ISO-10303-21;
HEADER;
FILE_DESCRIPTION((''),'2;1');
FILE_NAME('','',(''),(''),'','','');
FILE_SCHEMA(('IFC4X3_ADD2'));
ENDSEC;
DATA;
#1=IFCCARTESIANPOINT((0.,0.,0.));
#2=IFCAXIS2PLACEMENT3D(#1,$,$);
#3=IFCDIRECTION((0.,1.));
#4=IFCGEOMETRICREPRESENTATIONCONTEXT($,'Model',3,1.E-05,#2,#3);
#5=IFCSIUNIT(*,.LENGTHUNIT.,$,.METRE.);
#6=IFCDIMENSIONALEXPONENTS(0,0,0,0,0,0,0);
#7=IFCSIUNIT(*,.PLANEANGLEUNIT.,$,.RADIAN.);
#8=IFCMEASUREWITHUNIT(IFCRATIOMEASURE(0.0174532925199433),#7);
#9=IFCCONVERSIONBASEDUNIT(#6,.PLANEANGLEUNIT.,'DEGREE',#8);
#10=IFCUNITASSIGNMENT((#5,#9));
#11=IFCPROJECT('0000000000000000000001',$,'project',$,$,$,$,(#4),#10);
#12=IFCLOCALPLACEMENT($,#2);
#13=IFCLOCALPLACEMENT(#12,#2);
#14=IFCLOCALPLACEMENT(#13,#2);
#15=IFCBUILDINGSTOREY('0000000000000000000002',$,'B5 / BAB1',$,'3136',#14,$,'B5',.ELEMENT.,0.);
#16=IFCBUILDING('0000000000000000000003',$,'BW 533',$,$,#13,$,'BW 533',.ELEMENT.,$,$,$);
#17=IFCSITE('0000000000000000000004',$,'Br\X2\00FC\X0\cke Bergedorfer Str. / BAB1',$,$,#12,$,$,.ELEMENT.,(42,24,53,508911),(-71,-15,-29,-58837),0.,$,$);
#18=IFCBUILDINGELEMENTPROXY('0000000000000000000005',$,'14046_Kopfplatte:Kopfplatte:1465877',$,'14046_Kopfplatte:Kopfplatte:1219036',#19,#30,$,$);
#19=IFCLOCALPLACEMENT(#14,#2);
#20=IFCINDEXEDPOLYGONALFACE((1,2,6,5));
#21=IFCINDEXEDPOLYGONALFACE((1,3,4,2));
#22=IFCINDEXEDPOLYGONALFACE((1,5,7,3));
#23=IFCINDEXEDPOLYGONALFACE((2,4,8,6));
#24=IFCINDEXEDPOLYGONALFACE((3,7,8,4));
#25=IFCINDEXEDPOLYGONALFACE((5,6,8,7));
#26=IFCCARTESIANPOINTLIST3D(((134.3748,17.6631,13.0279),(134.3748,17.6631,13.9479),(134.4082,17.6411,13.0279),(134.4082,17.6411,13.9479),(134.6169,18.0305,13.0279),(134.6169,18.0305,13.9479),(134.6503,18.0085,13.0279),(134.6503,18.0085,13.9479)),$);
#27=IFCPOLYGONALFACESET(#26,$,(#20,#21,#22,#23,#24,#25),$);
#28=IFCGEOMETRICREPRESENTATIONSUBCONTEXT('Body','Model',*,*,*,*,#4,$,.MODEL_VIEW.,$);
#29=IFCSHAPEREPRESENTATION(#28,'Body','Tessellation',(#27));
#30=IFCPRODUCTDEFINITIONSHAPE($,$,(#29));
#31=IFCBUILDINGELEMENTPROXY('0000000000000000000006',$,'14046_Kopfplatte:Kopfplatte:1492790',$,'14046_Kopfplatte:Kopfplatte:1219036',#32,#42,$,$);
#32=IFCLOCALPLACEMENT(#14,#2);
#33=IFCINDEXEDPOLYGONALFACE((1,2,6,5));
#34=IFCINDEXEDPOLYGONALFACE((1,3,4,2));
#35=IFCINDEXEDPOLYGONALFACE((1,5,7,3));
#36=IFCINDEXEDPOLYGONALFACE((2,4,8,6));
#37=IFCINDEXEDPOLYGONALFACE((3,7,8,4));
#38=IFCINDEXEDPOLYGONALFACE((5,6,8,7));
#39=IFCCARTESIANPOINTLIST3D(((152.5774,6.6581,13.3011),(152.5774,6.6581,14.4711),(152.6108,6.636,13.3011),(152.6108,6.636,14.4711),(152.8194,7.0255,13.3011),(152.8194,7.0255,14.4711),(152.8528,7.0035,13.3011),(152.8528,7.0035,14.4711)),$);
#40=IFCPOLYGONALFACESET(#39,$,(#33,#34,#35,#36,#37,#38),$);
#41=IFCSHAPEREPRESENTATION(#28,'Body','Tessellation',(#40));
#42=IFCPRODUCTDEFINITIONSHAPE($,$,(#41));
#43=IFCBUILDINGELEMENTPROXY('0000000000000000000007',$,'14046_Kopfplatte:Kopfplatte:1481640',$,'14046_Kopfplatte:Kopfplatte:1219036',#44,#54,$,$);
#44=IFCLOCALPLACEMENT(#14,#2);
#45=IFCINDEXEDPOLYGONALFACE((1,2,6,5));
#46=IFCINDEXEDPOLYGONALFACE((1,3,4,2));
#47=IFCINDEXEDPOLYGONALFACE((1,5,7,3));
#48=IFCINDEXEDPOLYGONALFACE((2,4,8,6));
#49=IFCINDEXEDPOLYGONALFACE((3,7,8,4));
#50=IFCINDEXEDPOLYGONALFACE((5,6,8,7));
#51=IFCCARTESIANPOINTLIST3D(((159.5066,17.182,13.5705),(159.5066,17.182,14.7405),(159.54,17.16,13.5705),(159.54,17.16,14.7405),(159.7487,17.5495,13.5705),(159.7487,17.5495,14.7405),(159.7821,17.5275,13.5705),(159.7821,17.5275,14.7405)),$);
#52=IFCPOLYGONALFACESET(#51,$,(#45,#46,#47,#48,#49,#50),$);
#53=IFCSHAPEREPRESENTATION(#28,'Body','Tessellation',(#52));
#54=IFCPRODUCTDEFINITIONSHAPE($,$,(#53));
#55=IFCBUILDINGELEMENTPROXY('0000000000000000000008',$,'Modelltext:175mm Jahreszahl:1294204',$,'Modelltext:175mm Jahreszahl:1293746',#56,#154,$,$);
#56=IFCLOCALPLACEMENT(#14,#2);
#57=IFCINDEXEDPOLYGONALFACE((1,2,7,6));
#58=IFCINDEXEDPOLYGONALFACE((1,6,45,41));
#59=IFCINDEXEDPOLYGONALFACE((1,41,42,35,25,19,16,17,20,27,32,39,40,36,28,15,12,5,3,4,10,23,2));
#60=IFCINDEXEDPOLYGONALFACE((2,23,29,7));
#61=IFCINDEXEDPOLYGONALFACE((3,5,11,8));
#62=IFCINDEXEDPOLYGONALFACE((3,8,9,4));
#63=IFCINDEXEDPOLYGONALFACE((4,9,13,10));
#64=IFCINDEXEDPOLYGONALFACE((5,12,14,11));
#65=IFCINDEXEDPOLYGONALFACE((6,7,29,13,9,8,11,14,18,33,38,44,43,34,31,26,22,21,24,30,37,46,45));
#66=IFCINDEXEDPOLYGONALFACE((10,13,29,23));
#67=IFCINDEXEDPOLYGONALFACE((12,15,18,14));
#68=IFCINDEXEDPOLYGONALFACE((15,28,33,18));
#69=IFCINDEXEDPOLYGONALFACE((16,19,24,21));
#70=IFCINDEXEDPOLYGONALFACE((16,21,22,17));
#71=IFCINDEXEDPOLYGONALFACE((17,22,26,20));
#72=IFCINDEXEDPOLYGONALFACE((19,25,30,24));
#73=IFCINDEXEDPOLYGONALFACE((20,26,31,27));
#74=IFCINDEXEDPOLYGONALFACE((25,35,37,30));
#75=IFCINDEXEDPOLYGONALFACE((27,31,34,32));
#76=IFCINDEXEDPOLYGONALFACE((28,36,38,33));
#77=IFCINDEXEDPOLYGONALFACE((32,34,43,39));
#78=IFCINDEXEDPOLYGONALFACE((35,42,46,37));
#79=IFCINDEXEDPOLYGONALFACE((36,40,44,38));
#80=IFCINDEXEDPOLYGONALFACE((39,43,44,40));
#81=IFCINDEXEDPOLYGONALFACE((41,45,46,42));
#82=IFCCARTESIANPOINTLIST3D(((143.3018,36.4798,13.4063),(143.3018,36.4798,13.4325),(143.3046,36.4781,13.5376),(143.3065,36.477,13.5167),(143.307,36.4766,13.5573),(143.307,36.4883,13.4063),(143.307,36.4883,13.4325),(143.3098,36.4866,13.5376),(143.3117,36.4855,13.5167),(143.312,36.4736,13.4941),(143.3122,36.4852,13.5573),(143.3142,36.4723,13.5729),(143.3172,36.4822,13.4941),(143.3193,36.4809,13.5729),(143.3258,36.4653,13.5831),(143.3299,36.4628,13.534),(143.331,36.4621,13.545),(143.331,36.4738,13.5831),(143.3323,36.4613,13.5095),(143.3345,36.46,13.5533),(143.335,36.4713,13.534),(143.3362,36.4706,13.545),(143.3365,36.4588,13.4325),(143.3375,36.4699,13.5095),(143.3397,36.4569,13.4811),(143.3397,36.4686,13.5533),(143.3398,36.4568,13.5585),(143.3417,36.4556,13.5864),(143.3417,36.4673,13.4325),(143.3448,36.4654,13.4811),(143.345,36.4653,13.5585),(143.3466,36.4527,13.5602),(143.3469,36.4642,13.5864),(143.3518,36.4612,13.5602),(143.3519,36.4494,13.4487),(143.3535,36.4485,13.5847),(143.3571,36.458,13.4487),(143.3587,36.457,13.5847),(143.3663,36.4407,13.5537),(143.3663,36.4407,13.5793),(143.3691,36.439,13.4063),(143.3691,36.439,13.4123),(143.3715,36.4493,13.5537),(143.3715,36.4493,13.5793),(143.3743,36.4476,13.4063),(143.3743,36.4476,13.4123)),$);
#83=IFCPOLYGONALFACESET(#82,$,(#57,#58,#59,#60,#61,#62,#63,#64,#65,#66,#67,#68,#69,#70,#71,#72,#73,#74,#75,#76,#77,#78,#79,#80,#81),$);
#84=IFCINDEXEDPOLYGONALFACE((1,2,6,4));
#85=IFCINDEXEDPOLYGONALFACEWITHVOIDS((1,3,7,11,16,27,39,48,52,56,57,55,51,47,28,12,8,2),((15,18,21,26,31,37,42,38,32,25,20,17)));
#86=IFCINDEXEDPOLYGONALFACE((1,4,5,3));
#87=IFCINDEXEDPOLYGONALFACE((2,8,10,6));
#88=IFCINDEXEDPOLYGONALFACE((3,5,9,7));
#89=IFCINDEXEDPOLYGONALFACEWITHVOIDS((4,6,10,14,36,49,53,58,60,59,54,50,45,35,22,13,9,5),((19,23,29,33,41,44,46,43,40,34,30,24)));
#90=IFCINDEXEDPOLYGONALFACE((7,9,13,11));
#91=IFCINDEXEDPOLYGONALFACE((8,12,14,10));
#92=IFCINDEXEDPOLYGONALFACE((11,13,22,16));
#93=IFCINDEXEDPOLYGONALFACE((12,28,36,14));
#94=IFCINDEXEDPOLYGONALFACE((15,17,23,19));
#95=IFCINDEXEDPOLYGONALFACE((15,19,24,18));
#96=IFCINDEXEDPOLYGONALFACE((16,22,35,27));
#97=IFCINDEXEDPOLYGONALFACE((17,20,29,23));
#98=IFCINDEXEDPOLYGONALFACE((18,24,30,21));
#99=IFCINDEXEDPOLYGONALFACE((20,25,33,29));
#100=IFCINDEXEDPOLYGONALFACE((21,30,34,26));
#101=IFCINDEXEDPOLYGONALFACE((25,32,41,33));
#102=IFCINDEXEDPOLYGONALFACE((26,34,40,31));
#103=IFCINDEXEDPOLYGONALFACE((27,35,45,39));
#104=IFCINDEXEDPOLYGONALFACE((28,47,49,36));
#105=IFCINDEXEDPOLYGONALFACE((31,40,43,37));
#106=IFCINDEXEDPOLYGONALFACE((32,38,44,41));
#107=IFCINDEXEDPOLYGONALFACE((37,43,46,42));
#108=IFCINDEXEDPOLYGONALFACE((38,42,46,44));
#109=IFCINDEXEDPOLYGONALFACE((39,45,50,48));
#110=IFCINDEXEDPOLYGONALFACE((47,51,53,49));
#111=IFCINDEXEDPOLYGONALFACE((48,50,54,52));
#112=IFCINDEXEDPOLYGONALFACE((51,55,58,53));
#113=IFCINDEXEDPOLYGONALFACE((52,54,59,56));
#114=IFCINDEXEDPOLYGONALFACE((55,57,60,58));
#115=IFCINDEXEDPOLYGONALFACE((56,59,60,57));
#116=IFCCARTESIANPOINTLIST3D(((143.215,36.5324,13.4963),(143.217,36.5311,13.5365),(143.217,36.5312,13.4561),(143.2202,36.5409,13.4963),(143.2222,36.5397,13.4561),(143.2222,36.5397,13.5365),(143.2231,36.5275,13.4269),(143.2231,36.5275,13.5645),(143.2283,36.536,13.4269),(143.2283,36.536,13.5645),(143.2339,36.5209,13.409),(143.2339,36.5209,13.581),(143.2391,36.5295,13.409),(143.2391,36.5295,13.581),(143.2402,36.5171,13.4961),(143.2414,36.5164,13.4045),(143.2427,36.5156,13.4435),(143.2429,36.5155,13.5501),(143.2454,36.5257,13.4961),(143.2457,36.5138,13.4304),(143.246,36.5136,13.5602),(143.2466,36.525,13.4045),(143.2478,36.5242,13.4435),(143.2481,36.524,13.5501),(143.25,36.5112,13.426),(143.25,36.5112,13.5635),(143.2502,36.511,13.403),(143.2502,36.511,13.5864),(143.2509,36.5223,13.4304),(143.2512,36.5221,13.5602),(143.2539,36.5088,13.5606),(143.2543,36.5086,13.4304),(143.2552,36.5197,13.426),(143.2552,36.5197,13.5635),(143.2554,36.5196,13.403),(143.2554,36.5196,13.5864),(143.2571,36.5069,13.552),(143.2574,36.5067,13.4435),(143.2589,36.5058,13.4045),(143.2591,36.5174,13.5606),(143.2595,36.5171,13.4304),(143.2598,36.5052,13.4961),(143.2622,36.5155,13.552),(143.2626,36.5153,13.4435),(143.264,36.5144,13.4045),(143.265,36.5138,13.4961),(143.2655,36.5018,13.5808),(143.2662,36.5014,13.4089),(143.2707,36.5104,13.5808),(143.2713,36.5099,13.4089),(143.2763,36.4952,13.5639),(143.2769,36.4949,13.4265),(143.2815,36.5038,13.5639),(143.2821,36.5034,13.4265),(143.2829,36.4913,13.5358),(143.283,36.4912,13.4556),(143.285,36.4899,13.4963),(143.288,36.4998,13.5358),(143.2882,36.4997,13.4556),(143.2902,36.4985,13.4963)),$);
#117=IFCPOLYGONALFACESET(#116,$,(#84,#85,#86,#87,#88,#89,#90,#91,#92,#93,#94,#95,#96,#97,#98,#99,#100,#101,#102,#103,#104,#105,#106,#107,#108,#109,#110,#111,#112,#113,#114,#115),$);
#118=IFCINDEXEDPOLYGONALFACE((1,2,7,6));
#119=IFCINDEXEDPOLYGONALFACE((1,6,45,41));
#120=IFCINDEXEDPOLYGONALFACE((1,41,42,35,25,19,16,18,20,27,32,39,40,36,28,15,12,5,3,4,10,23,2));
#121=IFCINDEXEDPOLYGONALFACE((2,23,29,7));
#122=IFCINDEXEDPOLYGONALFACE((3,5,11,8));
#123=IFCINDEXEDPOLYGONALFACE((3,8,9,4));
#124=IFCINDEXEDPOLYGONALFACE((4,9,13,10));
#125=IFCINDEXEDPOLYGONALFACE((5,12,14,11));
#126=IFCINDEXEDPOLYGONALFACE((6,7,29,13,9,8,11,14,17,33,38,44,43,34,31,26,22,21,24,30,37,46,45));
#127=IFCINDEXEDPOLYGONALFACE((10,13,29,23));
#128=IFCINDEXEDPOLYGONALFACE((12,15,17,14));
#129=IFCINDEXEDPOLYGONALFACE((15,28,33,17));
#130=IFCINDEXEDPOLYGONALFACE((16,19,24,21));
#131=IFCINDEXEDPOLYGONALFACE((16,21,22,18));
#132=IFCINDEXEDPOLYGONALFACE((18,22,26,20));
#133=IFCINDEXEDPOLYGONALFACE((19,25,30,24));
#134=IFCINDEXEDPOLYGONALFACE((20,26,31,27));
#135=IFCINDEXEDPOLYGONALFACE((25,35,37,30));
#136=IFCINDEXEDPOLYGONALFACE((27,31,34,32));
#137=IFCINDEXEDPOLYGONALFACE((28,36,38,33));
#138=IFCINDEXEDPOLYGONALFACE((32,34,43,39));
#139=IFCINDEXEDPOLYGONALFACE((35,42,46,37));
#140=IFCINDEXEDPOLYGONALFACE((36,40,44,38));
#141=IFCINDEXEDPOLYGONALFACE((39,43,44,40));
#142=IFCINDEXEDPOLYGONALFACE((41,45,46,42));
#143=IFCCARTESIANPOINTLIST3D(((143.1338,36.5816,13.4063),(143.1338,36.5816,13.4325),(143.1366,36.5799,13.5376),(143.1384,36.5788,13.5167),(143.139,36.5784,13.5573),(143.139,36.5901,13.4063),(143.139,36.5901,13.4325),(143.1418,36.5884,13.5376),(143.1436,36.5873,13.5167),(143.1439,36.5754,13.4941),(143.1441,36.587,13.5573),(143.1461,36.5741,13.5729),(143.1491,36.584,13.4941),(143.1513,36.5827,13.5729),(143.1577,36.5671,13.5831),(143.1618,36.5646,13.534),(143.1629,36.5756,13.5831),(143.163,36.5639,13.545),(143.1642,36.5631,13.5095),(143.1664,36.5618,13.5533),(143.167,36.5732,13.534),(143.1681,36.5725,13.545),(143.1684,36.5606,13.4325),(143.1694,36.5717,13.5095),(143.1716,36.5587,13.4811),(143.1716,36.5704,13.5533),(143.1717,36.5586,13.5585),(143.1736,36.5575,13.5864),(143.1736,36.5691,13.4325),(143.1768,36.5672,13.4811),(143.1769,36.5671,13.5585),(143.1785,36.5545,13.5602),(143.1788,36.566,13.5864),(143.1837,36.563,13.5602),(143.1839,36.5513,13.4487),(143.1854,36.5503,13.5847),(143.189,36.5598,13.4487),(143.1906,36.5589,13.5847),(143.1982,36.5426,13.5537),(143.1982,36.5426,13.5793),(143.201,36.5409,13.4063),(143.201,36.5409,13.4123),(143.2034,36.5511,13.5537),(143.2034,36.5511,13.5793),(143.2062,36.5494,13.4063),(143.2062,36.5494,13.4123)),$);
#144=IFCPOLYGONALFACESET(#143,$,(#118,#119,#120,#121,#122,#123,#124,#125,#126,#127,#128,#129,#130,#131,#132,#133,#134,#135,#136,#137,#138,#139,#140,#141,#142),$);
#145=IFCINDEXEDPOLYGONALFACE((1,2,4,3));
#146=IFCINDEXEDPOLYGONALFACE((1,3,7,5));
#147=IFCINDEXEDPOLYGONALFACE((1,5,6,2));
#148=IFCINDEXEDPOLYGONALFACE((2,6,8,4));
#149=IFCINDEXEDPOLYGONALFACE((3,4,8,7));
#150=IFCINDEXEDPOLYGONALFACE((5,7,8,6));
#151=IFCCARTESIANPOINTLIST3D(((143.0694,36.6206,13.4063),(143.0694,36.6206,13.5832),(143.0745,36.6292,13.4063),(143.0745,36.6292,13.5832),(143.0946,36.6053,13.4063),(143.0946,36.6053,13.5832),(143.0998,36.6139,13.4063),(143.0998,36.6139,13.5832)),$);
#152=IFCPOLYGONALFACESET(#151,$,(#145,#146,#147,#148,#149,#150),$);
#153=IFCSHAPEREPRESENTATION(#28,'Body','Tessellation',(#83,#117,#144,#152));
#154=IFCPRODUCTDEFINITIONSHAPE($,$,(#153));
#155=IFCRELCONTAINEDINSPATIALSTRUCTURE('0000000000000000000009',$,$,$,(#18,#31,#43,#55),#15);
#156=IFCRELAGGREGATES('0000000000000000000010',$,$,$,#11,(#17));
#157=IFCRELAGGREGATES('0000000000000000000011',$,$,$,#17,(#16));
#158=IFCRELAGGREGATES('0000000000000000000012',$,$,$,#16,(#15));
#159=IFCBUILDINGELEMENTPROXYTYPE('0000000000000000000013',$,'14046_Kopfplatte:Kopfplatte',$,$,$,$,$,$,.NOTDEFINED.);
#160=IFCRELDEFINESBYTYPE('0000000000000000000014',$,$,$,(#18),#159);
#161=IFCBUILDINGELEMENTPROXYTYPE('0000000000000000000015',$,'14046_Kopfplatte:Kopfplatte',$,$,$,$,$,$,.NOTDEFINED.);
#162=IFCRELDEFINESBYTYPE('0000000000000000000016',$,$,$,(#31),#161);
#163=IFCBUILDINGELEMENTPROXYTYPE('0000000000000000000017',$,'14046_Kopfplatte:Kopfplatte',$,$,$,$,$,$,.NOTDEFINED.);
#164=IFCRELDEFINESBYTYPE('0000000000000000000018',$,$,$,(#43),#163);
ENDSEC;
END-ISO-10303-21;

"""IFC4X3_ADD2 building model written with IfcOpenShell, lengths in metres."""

from ifc_helpers import new_model, entity, si_unit, converted_unit, direction, frame, frame_2d, origin, origin_2d_with_axis, place, context, subcontext, project, spatial, polyline, rectangle, outline, extrude, source, transform, mapped, type_object, type_shapes, element, save


model = new_model("IFC4X3_ADD2")

# Units and contexts
model_context = context("Model", 3, precision=1e-05, world=origin(), true_north=direction((0.0, 1.0)))
body_context = subcontext(model_context, "Body", "Model", "MODEL_VIEW")
ifc_project = project(units=[si_unit("LENGTHUNIT", "METRE"), converted_unit("PLANEANGLEUNIT", "DEGREE", entity("IfcRatioMeasure", 0.0174532925199433), si_unit("PLANEANGLEUNIT", "RADIAN"), dimensions=[0, 0, 0, 0, 0, 0, 0])], contexts=[model_context])

# Site, building, storey
site_placement = place(None, origin())
site = spatial("IfcSite", under=ifc_project, at=site_placement, Name="Brücke Bergedorfer Str. / BAB1", CompositionType="ELEMENT", RefLatitude=(42, 24, 53, 508911), RefLongitude=(-71, -15, -29, -58837), RefElevation=0.0)
building_placement = place(site_placement, origin())
building = spatial("IfcBuilding", under=site, at=building_placement, Name="BW 533", LongName="BW 533", CompositionType="ELEMENT")
storey_placement = place(building_placement, origin())
storey = spatial("IfcBuildingStorey", under=building, at=storey_placement, Name="B5 / BAB1", ObjectType="3136", LongName="B5", CompositionType="ELEMENT", Elevation=0.0)

# Building element proxies
building_element_proxy_type_1 = type_object("IfcBuildingElementProxyType", Name="14046_Kopfplatte:Kopfplatte", PredefinedType="NOTDEFINED")
shared_shape_1 = source(origin(), body_context, "Body", "SweptSolid", [
    extrude(rectangle(XDim=0.04, YDim=0.44, at=frame_2d((0.0, 0.0), x_axis=(1.0, 0.0))), frame((134.5126, 17.8358, 13.0279), z_axis=(0.0, 0.0, 1.0), x_axis=(-0.835088, 0.550116, 0.0)), (0.0, 0.0, 1.0), 0.92),
])
type_shapes(building_element_proxy_type_1, [shared_shape_1])
proxy_1_placement = place(storey_placement, origin())
element("IfcBuildingElementProxy", 1, at=proxy_1_placement, inside=storey, type_object=building_element_proxy_type_1, Name="14046_Kopfplatte:Kopfplatte:1465877", ObjectType="14046_Kopfplatte:Kopfplatte:1219036", context=body_context, shape_type="MappedRepresentation", body=[
    mapped(shared_shape_1, transform((0.0, 0.0, 0.0), scale=1.0)),
])
building_element_proxy_type_2 = type_object("IfcBuildingElementProxyType", Name="14046_Kopfplatte:Kopfplatte", PredefinedType="NOTDEFINED")
shared_shape_2 = source(origin(), body_context, "Body", "SweptSolid", [
    extrude(rectangle(XDim=0.04, YDim=0.44, at=origin_2d_with_axis()), frame((152.7151, 6.8308, 13.3011), z_axis=(0.0, 0.0, 1.0), x_axis=(0.835088, -0.550116, 0.0)), (0.0, 0.0, 1.0), 1.17),
])
type_shapes(building_element_proxy_type_2, [shared_shape_2])
proxy_2_placement = place(storey_placement, origin())
element("IfcBuildingElementProxy", 2, at=proxy_2_placement, inside=storey, type_object=building_element_proxy_type_2, Name="14046_Kopfplatte:Kopfplatte:1492790", ObjectType="14046_Kopfplatte:Kopfplatte:1219036", context=body_context, shape_type="MappedRepresentation", body=[
    mapped(shared_shape_2, transform((0.0, 0.0, 0.0), scale=1.0)),
])
building_element_proxy_type_3 = type_object("IfcBuildingElementProxyType", Name="14046_Kopfplatte:Kopfplatte", PredefinedType="NOTDEFINED")
shared_shape_3 = source(origin(), body_context, "Body", "SweptSolid", [
    extrude(rectangle(XDim=0.04, YDim=0.44, at=frame_2d((0.0, 0.0), x_axis=(1.0, 0.0))), frame((159.6443, 17.3547, 13.5705), z_axis=(0.0, 0.0, 1.0), x_axis=(0.835088, -0.550116, 0.0)), (0.0, 0.0, 1.0), 1.17),
])
type_shapes(building_element_proxy_type_3, [shared_shape_3])
proxy_3_placement = place(storey_placement, origin())
element("IfcBuildingElementProxy", 3, at=proxy_3_placement, inside=storey, type_object=building_element_proxy_type_3, Name="14046_Kopfplatte:Kopfplatte:1481640", ObjectType="14046_Kopfplatte:Kopfplatte:1219036", context=body_context, shape_type="MappedRepresentation", body=[
    mapped(shared_shape_3, transform((0.0, 0.0, 0.0), scale=1.0)),
])
proxy_4_placement = place(storey_placement, origin())
element("IfcBuildingElementProxy", 4, at=proxy_4_placement, inside=storey, Name="Modelltext:175mm Jahreszahl:1294204", ObjectType="Modelltext:175mm Jahreszahl:1293746", context=body_context, shape_type="SweptSolid", body=[
    extrude(outline(polyline([(-0.041, -0.1087), (0.0376, -0.1087), (0.0376, -0.0825), (-0.0029, -0.0825), (0.0257, -0.021), (0.0322, 0.0016), (0.0343, 0.0226), (0.0315, 0.0423), (0.0232, 0.0579), (0.0096, 0.068), (-0.009, 0.0714), (-0.0228, 0.0696), (-0.0377, 0.0643), (-0.0377, 0.0386), (-0.0147, 0.0452), (-0.0068, 0.0434), (-0.0006, 0.0382), (0.0035, 0.0299), (0.0048, 0.019), (0.002, -0.0055), (-0.0066, -0.034), (-0.021, -0.0664), (-0.041, -0.1027), (-0.041, -0.1087)])), frame((143.334, 36.4603, 13.515), z_axis=(0.518179, 0.855272, 0.0), x_axis=(-0.855272, 0.518179, 0.0)), (0.0, 0.0, 1.0), 0.01),
    extrude(outline(polyline([(-0.012, -0.0814), (-0.0015, -0.0814), (0.0078, -0.0783), (0.0228, -0.0624), (0.034, -0.0344), (0.042, 0.005), (0.0454, 0.0451), (0.0423, 0.0739), (0.0321, 0.092), (0.0141, 0.1001), (-0.0044, 0.097), (-0.0194, 0.0821), (-0.0309, 0.0553), (-0.039, 0.0167), (-0.0424, -0.024), (-0.0395, -0.0538), (-0.0296, -0.073), (-0.0218, -0.0786), (-0.012, -0.0814)]), holes=[polyline([(0.0128, 0.009), (0.0025, -0.0427), (-0.0029, -0.0552), (-0.0084, -0.0588), (-0.0128, -0.0537), (-0.0145, -0.0402), (-0.0099, 0.0123), (0.0013, 0.0671), (0.0062, 0.0752), (0.0111, 0.0774), (0.0152, 0.0734), (0.0174, 0.0629), (0.0128, 0.009)])]), frame((143.25, 36.5112, 13.4854), z_axis=(0.518179, 0.855272, 0.0), x_axis=(-0.846595, 0.512922, 0.142084)), (0.0, 0.0, 1.0), 0.01),
    extrude(outline(polyline([(-0.041, -0.1087), (0.0376, -0.1087), (0.0376, -0.0825), (-0.0029, -0.0825), (0.0257, -0.021), (0.0322, 0.0016), (0.0343, 0.0226), (0.0315, 0.0423), (0.0232, 0.0579), (0.0096, 0.068), (-0.009, 0.0714), (-0.0228, 0.0696), (-0.0377, 0.0643), (-0.0377, 0.0386), (-0.0147, 0.0452), (-0.0068, 0.0434), (-0.0006, 0.0382), (0.0035, 0.0299), (0.0048, 0.019), (0.002, -0.0055), (-0.0066, -0.034), (-0.021, -0.0664), (-0.041, -0.1027), (-0.041, -0.1087)])), frame((143.1659, 36.5621, 13.515), z_axis=(0.518179, 0.855272, 0.0), x_axis=(-0.855272, 0.518179, 0.0)), (0.0, 0.0, 1.0), 0.01),
    extrude(rectangle(XDim=0.01, YDim=0.0295, at=frame_2d((0.0, 0.0), x_axis=(1.0, 0.0))), frame((143.0846, 36.6173, 13.4063), z_axis=(0.0, 0.0, 1.0), x_axis=(-0.518179, -0.855272, 0.0)), (0.0, 0.0, 1.0), 0.1768),
])

save(model, "model.ifc")
